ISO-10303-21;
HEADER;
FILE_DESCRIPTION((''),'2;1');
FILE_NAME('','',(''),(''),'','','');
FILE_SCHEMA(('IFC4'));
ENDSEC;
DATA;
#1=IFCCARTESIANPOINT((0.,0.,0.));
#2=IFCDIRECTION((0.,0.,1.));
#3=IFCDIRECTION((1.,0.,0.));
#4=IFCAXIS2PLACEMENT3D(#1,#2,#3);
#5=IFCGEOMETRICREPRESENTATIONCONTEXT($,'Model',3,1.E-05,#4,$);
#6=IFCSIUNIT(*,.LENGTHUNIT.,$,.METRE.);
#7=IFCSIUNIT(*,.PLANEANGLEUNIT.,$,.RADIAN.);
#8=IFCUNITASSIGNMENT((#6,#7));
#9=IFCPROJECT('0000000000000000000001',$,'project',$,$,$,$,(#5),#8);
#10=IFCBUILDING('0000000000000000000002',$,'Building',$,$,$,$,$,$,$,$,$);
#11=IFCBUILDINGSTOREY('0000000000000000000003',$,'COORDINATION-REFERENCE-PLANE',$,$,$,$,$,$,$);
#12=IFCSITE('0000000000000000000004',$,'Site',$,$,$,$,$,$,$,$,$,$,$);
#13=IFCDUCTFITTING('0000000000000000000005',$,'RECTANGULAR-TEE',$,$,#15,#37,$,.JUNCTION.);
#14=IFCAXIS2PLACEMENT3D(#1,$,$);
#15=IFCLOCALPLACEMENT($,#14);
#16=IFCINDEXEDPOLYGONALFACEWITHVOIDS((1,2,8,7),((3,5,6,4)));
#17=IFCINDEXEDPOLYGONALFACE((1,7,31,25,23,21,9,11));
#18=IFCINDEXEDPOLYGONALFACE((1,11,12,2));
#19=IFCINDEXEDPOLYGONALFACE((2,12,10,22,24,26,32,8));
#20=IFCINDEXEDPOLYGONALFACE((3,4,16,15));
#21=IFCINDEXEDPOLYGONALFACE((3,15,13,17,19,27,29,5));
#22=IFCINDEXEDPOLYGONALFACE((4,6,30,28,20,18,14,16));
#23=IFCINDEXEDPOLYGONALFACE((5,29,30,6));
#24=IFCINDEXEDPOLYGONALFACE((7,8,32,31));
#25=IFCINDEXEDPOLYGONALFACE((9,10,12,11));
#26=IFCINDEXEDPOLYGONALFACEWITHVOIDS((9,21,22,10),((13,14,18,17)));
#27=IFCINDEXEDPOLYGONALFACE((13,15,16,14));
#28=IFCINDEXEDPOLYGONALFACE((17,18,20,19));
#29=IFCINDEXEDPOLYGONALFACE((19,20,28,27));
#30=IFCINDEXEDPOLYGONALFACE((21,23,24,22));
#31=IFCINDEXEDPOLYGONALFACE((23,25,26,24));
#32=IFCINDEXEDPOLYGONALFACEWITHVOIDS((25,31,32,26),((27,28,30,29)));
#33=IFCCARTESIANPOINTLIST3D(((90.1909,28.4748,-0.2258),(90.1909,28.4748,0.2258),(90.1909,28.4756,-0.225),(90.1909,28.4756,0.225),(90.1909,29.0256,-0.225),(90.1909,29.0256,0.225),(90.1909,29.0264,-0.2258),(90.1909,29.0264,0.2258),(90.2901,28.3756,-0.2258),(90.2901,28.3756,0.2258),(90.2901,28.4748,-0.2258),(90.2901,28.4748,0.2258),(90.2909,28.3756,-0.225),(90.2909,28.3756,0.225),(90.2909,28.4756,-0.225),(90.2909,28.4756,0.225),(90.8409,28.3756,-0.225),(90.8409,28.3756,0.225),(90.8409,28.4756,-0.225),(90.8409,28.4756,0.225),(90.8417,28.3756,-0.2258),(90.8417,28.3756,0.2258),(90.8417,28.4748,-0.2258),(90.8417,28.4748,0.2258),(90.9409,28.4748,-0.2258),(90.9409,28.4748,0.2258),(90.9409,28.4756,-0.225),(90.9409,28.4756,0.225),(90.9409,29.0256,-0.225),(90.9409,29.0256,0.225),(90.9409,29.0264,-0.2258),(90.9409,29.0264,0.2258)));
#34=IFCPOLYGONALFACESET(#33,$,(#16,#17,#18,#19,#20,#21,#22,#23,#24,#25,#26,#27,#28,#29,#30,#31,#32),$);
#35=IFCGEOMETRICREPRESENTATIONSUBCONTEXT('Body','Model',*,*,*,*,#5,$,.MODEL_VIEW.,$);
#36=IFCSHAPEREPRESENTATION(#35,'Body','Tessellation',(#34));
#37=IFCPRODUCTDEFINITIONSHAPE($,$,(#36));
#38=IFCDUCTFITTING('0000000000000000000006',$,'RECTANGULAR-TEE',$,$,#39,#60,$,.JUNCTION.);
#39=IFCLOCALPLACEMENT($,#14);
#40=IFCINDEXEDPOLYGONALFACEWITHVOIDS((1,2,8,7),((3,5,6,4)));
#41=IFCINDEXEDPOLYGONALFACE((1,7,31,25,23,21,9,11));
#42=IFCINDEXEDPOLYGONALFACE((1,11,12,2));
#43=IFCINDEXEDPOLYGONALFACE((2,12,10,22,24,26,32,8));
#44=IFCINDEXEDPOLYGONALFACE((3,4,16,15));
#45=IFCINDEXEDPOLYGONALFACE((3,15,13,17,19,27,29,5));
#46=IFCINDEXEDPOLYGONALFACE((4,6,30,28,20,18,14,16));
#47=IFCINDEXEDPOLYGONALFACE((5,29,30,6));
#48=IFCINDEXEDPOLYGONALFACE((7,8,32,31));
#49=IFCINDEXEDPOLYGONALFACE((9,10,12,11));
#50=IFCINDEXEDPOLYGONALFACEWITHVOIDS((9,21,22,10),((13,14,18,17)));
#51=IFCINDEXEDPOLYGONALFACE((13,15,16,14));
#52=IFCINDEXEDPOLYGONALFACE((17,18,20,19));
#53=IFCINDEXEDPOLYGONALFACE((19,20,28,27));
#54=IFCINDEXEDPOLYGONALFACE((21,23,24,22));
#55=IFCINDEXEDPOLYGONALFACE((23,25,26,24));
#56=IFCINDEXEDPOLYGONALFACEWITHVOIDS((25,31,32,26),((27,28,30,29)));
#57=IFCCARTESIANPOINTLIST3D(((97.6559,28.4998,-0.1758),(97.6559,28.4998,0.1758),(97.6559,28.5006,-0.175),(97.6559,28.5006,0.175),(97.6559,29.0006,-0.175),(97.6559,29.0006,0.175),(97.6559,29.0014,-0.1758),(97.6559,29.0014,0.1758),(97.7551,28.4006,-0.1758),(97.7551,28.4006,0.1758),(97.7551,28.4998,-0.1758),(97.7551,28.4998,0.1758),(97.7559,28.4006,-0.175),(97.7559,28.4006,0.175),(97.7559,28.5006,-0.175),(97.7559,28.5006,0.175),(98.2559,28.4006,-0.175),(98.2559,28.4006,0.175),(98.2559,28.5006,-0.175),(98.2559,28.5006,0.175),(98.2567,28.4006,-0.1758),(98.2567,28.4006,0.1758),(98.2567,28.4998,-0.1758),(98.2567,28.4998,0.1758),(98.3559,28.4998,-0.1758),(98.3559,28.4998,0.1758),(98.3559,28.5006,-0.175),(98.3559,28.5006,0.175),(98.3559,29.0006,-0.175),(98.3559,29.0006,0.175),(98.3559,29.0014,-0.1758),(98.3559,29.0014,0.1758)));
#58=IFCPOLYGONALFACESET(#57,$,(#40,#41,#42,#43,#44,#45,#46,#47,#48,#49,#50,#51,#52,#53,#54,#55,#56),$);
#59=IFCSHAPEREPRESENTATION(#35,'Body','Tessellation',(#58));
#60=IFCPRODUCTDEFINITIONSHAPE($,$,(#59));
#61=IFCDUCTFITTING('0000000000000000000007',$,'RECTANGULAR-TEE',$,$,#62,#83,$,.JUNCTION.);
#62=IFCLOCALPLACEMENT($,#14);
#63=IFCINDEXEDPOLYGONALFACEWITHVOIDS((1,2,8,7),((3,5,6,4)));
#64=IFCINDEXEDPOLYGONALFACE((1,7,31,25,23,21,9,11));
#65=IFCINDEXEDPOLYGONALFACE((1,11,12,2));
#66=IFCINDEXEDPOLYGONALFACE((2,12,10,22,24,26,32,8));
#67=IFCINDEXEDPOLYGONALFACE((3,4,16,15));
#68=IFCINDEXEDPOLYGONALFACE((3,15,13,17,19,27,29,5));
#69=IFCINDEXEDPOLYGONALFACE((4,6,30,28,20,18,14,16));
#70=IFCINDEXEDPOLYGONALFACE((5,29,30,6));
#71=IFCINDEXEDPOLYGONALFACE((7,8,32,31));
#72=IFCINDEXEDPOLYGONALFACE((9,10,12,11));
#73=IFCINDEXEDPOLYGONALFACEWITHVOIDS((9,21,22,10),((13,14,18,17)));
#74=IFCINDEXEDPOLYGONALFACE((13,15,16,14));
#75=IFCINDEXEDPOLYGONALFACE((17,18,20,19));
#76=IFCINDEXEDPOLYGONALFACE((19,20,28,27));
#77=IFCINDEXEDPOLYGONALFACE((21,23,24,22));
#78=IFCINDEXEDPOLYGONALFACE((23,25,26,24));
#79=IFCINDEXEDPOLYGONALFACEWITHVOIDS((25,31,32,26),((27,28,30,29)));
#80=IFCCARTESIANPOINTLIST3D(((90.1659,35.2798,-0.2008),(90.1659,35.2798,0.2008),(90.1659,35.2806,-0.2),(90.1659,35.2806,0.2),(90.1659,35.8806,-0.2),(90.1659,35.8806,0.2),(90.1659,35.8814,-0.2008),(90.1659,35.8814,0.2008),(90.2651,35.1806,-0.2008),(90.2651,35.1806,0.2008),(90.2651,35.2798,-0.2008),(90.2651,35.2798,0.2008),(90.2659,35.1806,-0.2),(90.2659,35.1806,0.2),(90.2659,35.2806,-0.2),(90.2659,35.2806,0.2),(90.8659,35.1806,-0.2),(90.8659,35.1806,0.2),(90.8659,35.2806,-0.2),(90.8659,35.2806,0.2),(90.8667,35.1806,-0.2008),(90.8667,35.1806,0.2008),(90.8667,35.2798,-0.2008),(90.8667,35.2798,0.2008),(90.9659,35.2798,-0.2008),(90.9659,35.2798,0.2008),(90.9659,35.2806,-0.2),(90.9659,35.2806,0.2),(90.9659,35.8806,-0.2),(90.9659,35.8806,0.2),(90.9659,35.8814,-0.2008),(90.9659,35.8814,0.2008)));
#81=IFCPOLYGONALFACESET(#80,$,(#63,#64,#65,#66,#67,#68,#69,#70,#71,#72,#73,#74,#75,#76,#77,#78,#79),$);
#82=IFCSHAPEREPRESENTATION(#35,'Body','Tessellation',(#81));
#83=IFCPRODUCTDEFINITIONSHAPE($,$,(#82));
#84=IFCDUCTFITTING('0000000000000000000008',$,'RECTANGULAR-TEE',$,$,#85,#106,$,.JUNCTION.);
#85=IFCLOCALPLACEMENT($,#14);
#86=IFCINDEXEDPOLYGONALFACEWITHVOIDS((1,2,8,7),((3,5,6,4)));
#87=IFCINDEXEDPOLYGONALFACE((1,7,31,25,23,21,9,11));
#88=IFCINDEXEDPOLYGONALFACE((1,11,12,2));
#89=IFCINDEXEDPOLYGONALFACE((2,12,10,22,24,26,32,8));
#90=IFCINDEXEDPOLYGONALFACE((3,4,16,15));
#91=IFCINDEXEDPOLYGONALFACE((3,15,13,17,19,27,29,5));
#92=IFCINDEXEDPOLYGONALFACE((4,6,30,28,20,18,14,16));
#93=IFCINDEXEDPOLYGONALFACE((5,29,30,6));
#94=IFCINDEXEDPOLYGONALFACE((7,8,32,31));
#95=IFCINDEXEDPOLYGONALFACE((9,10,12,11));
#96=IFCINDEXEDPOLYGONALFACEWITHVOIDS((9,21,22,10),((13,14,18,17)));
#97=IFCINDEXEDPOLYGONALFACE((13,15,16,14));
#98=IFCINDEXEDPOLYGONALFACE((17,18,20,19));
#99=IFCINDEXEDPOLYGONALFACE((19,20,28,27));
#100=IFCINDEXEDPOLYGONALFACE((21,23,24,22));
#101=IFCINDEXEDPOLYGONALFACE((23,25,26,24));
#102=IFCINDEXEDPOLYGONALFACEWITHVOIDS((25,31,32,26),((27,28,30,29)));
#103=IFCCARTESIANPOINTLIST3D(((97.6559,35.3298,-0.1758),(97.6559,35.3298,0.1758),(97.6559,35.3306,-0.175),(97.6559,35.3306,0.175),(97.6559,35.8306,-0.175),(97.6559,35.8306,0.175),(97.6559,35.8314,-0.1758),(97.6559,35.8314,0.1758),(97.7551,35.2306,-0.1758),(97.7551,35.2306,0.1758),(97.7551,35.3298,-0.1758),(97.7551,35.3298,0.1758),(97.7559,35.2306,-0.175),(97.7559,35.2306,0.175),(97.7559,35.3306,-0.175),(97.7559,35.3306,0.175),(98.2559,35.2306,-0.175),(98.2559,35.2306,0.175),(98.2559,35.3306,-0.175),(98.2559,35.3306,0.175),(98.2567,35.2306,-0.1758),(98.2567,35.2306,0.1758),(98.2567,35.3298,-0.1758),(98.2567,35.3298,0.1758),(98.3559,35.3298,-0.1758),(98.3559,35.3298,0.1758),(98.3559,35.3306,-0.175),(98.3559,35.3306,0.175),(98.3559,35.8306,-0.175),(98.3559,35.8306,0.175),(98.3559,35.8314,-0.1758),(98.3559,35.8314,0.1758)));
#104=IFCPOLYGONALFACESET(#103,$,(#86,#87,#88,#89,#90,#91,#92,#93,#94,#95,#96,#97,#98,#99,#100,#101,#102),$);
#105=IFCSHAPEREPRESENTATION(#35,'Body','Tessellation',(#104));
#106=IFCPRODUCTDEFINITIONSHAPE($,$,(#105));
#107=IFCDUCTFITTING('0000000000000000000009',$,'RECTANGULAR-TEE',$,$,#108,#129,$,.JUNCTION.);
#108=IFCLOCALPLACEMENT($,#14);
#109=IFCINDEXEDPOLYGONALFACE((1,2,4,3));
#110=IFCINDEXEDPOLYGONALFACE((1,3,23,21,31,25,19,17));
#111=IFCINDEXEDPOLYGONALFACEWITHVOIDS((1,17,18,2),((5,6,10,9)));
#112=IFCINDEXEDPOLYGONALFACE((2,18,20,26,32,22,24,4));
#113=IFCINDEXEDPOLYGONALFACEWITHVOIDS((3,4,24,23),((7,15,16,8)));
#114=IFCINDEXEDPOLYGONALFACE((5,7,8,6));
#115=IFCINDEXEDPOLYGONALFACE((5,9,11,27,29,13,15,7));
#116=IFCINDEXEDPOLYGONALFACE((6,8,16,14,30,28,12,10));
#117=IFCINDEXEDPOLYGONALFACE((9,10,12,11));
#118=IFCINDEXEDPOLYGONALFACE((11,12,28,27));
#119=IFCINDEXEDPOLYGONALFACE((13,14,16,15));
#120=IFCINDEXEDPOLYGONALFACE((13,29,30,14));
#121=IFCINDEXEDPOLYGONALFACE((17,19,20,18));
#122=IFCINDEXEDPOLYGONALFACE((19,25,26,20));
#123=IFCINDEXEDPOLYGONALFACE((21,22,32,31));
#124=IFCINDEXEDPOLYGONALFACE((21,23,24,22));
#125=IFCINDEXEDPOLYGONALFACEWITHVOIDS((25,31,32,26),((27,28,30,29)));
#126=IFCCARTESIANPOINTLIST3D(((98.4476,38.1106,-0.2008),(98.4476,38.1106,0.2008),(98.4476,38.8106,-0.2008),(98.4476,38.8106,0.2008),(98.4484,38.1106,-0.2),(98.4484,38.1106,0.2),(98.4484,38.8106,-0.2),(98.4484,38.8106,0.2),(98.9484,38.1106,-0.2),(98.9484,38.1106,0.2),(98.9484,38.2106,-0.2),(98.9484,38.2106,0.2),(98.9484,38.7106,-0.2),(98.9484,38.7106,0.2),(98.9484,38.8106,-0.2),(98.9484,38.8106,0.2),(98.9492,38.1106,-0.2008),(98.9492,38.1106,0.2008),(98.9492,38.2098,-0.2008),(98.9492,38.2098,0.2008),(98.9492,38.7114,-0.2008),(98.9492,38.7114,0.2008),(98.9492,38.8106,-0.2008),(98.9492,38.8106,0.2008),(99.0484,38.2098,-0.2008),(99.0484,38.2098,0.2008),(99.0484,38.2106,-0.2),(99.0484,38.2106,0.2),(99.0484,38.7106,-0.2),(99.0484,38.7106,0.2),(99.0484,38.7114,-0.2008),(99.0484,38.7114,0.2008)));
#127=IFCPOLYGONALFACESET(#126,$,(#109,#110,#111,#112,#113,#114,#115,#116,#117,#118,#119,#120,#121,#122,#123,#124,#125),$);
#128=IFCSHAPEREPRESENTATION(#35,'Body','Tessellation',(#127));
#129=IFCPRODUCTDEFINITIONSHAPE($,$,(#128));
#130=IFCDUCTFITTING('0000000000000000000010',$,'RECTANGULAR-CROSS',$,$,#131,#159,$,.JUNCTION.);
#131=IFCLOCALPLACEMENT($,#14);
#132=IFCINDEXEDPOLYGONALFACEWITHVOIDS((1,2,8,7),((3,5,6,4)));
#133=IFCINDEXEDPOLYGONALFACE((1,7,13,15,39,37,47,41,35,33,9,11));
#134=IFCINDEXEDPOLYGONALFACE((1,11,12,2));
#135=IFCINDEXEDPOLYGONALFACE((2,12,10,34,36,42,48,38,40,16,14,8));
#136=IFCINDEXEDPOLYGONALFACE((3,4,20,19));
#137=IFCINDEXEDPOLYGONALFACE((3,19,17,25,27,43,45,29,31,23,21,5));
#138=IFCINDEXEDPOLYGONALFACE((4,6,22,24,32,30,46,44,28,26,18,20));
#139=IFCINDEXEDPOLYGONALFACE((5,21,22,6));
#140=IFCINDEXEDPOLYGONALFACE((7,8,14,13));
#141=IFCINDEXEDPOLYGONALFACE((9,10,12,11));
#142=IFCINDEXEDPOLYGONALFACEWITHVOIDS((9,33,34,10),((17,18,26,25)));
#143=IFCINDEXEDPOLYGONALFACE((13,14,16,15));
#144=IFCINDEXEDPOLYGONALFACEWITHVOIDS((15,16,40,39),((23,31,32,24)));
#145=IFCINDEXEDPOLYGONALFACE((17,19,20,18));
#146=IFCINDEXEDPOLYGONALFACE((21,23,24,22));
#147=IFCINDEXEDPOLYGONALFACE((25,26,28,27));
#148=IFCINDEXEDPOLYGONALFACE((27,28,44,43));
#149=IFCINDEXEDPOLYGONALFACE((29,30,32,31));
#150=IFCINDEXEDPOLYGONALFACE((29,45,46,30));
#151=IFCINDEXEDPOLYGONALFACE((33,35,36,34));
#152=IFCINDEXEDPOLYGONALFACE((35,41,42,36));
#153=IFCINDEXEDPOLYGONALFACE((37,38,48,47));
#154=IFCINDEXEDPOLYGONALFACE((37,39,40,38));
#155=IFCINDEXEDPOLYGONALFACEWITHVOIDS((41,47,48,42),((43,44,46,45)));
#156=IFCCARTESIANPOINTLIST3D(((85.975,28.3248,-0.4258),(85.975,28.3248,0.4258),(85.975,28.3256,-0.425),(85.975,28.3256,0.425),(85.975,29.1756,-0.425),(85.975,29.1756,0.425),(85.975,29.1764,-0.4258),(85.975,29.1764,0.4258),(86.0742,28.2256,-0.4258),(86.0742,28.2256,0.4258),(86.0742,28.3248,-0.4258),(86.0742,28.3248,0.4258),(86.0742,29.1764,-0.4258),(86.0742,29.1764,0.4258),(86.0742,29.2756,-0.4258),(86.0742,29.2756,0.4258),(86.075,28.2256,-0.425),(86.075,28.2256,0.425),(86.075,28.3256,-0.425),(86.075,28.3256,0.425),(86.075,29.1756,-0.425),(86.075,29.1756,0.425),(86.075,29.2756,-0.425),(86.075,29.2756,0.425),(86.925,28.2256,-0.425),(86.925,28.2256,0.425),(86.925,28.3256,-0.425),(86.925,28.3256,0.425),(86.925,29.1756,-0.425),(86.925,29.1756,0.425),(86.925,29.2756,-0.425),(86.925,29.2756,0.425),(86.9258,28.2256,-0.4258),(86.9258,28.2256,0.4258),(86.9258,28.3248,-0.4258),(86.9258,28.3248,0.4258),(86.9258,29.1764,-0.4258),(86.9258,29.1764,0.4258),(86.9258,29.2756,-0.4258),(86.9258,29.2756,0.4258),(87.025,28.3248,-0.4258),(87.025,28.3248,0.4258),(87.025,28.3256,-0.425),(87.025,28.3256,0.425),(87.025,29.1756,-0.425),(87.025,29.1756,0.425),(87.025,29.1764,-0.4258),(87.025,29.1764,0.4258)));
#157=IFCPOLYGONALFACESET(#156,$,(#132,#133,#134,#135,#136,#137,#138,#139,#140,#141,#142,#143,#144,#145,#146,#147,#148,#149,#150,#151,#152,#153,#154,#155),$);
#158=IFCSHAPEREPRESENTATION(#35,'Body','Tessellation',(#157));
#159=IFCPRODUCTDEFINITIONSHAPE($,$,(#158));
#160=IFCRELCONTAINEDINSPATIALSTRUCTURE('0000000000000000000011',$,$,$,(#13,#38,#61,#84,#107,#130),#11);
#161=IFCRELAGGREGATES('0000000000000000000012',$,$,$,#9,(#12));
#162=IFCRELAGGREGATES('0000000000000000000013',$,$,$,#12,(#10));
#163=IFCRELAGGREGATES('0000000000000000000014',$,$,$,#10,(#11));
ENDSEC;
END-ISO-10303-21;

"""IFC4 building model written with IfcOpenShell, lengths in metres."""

from ifc_helpers import new_model, si_unit, frame, origin_with_axes, place, context, subcontext, project, spatial, rectangle, extrude, boolean, element, save


model = new_model("IFC4")

# Units and contexts
model_context = context("Model", 3, precision=1e-05, world=origin_with_axes())
body_context = subcontext(model_context, "Body", "Model", "MODEL_VIEW")
ifc_project = project(units=[si_unit("LENGTHUNIT", "METRE"), si_unit("PLANEANGLEUNIT", "RADIAN")], contexts=[model_context])

# Site, building, storey
site = spatial("IfcSite", under=ifc_project, Name="Site")
building = spatial("IfcBuilding", under=site, Name="Building")
storey = spatial("IfcBuildingStorey", under=building, Name="COORDINATION-REFERENCE-PLANE")

# Duct fittings
duct_fitting_1_placement = place(None, frame((90.5659, 28.7506, 0.0), z_axis=(1.0, 0.0, 0.0), x_axis=(0.0, -1.0, 0.0)))
solid_1 = boolean("UNION", extrude(rectangle(XDim=0.55, YDim=0.45), frame((0.0, 0.0, -0.375), z_axis=(0.0, 0.0, 1.0), x_axis=(1.0, 0.0, 0.0)), (0.0, 0.0, 1.0), 0.75), extrude(rectangle(XDim=0.55, YDim=0.45), frame((0.0, 0.0, 0.0), z_axis=(1.0, 0.0, 0.0), x_axis=(0.0, 0.0, -1.0)), (0.0, 0.0, 1.0), 0.375))
element("IfcDuctFitting", 1, at=duct_fitting_1_placement, inside=storey, Name="RECTANGULAR-TEE", PredefinedType="JUNCTION", context=body_context, shape_type="CSG", body=[
    boolean("DIFFERENCE", boolean("UNION", extrude(rectangle(XDim=0.5516, YDim=0.4516), frame((0.0, 0.0, -0.375), z_axis=(0.0, 0.0, 1.0), x_axis=(1.0, 0.0, 0.0)), (0.0, 0.0, 1.0), 0.75), extrude(rectangle(XDim=0.5516, YDim=0.4516), frame((0.0, 0.0, 0.0), z_axis=(1.0, 0.0, 0.0), x_axis=(0.0, 0.0, -1.0)), (0.0, 0.0, 1.0), 0.375)), solid_1),
])
duct_fitting_2_placement = place(None, frame((98.0059, 28.7506, 0.0), z_axis=(1.0, 0.0, 0.0), x_axis=(0.0, -1.0, 0.0)))
solid_2 = boolean("UNION", extrude(rectangle(XDim=0.5, YDim=0.35), frame((0.0, 0.0, -0.35), z_axis=(0.0, 0.0, 1.0), x_axis=(1.0, 0.0, 0.0)), (0.0, 0.0, 1.0), 0.7), extrude(rectangle(XDim=0.5, YDim=0.35), frame((0.0, 0.0, 0.0), z_axis=(1.0, 0.0, 0.0), x_axis=(0.0, 0.0, -1.0)), (0.0, 0.0, 1.0), 0.35))
element("IfcDuctFitting", 2, at=duct_fitting_2_placement, inside=storey, Name="RECTANGULAR-TEE", PredefinedType="JUNCTION", context=body_context, shape_type="CSG", body=[
    boolean("DIFFERENCE", boolean("UNION", extrude(rectangle(XDim=0.5016, YDim=0.3516), frame((0.0, 0.0, -0.35), z_axis=(0.0, 0.0, 1.0), x_axis=(1.0, 0.0, 0.0)), (0.0, 0.0, 1.0), 0.7), extrude(rectangle(XDim=0.5016, YDim=0.3516), frame((0.0, 0.0, 0.0), z_axis=(1.0, 0.0, 0.0), x_axis=(0.0, 0.0, -1.0)), (0.0, 0.0, 1.0), 0.35)), solid_2),
])
duct_fitting_3_placement = place(None, frame((90.5659, 35.5806, 0.0), z_axis=(1.0, 0.0, 0.0), x_axis=(0.0, -1.0, 0.0)))
solid_3 = boolean("UNION", extrude(rectangle(XDim=0.6, YDim=0.4), frame((0.0, 0.0, -0.4), z_axis=(0.0, 0.0, 1.0), x_axis=(1.0, 0.0, 0.0)), (0.0, 0.0, 1.0), 0.8), extrude(rectangle(XDim=0.6, YDim=0.4), frame((0.0, 0.0, 0.0), z_axis=(1.0, 0.0, 0.0), x_axis=(0.0, 0.0, -1.0)), (0.0, 0.0, 1.0), 0.4))
element("IfcDuctFitting", 3, at=duct_fitting_3_placement, inside=storey, Name="RECTANGULAR-TEE", PredefinedType="JUNCTION", context=body_context, shape_type="CSG", body=[
    boolean("DIFFERENCE", boolean("UNION", extrude(rectangle(XDim=0.6016, YDim=0.4016), frame((0.0, 0.0, -0.4), z_axis=(0.0, 0.0, 1.0), x_axis=(1.0, 0.0, 0.0)), (0.0, 0.0, 1.0), 0.8), extrude(rectangle(XDim=0.6016, YDim=0.4016), frame((0.0, 0.0, 0.0), z_axis=(1.0, 0.0, 0.0), x_axis=(0.0, 0.0, -1.0)), (0.0, 0.0, 1.0), 0.4)), solid_3),
])
duct_fitting_4_placement = place(None, frame((98.0059, 35.5806, 0.0), z_axis=(1.0, 0.0, 0.0), x_axis=(0.0, -1.0, 0.0)))
solid_4 = boolean("UNION", extrude(rectangle(XDim=0.5, YDim=0.35), frame((0.0, 0.0, -0.35), z_axis=(0.0, 0.0, 1.0), x_axis=(1.0, 0.0, 0.0)), (0.0, 0.0, 1.0), 0.7), extrude(rectangle(XDim=0.5, YDim=0.35), frame((0.0, 0.0, 0.0), z_axis=(1.0, 0.0, 0.0), x_axis=(0.0, 0.0, -1.0)), (0.0, 0.0, 1.0), 0.35))
element("IfcDuctFitting", 4, at=duct_fitting_4_placement, inside=storey, Name="RECTANGULAR-TEE", PredefinedType="JUNCTION", context=body_context, shape_type="CSG", body=[
    boolean("DIFFERENCE", boolean("UNION", extrude(rectangle(XDim=0.5016, YDim=0.3516), frame((0.0, 0.0, -0.35), z_axis=(0.0, 0.0, 1.0), x_axis=(1.0, 0.0, 0.0)), (0.0, 0.0, 1.0), 0.7), extrude(rectangle(XDim=0.5016, YDim=0.3516), frame((0.0, 0.0, 0.0), z_axis=(1.0, 0.0, 0.0), x_axis=(0.0, 0.0, -1.0)), (0.0, 0.0, 1.0), 0.35)), solid_4),
])
duct_fitting_5_placement = place(None, frame((98.6984, 38.4606, 0.0), z_axis=(0.0, 1.0, 0.0), x_axis=(1.0, 0.0, 0.0)))
solid_5 = boolean("UNION", extrude(rectangle(XDim=0.5, YDim=0.4), frame((0.0, 0.0, -0.35), z_axis=(0.0, 0.0, 1.0), x_axis=(1.0, 0.0, 0.0)), (0.0, 0.0, 1.0), 0.7), extrude(rectangle(XDim=0.5, YDim=0.4), frame((0.0, 0.0, 0.0), z_axis=(1.0, 0.0, 0.0), x_axis=(0.0, 0.0, -1.0)), (0.0, 0.0, 1.0), 0.35))
element("IfcDuctFitting", 5, at=duct_fitting_5_placement, inside=storey, Name="RECTANGULAR-TEE", PredefinedType="JUNCTION", context=body_context, shape_type="CSG", body=[
    boolean("DIFFERENCE", boolean("UNION", extrude(rectangle(XDim=0.5016, YDim=0.4016), frame((0.0, 0.0, -0.35), z_axis=(0.0, 0.0, 1.0), x_axis=(1.0, 0.0, 0.0)), (0.0, 0.0, 1.0), 0.7), extrude(rectangle(XDim=0.5016, YDim=0.4016), frame((0.0, 0.0, 0.0), z_axis=(1.0, 0.0, 0.0), x_axis=(0.0, 0.0, -1.0)), (0.0, 0.0, 1.0), 0.35)), solid_5),
])
duct_fitting_6_placement = place(None, frame((86.5, 28.7506, 0.0), z_axis=(0.0, -1.0, 0.0), x_axis=(1.0, 0.0, 0.0)))
solid_6 = boolean("UNION", extrude(rectangle(XDim=0.85, YDim=0.85), frame((0.0, 0.0, -0.525), z_axis=(0.0, 0.0, 1.0), x_axis=(1.0, 0.0, 0.0)), (0.0, 0.0, 1.0), 1.05), extrude(rectangle(XDim=0.85, YDim=0.85), frame((-0.525, 0.0, 0.0), z_axis=(1.0, 0.0, 0.0), x_axis=(0.0, 0.0, -1.0)), (0.0, 0.0, 1.0), 1.05))
element("IfcDuctFitting", 6, at=duct_fitting_6_placement, inside=storey, Name="RECTANGULAR-CROSS", PredefinedType="JUNCTION", context=body_context, shape_type="CSG", body=[
    boolean("DIFFERENCE", boolean("UNION", extrude(rectangle(XDim=0.8516, YDim=0.8516), frame((0.0, 0.0, -0.525), z_axis=(0.0, 0.0, 1.0), x_axis=(1.0, 0.0, 0.0)), (0.0, 0.0, 1.0), 1.05), extrude(rectangle(XDim=0.8516, YDim=0.8516), frame((-0.525, 0.0, 0.0), z_axis=(1.0, 0.0, 0.0), x_axis=(0.0, 0.0, -1.0)), (0.0, 0.0, 1.0), 1.05)), solid_6),
])

save(model, "model.ifc")
